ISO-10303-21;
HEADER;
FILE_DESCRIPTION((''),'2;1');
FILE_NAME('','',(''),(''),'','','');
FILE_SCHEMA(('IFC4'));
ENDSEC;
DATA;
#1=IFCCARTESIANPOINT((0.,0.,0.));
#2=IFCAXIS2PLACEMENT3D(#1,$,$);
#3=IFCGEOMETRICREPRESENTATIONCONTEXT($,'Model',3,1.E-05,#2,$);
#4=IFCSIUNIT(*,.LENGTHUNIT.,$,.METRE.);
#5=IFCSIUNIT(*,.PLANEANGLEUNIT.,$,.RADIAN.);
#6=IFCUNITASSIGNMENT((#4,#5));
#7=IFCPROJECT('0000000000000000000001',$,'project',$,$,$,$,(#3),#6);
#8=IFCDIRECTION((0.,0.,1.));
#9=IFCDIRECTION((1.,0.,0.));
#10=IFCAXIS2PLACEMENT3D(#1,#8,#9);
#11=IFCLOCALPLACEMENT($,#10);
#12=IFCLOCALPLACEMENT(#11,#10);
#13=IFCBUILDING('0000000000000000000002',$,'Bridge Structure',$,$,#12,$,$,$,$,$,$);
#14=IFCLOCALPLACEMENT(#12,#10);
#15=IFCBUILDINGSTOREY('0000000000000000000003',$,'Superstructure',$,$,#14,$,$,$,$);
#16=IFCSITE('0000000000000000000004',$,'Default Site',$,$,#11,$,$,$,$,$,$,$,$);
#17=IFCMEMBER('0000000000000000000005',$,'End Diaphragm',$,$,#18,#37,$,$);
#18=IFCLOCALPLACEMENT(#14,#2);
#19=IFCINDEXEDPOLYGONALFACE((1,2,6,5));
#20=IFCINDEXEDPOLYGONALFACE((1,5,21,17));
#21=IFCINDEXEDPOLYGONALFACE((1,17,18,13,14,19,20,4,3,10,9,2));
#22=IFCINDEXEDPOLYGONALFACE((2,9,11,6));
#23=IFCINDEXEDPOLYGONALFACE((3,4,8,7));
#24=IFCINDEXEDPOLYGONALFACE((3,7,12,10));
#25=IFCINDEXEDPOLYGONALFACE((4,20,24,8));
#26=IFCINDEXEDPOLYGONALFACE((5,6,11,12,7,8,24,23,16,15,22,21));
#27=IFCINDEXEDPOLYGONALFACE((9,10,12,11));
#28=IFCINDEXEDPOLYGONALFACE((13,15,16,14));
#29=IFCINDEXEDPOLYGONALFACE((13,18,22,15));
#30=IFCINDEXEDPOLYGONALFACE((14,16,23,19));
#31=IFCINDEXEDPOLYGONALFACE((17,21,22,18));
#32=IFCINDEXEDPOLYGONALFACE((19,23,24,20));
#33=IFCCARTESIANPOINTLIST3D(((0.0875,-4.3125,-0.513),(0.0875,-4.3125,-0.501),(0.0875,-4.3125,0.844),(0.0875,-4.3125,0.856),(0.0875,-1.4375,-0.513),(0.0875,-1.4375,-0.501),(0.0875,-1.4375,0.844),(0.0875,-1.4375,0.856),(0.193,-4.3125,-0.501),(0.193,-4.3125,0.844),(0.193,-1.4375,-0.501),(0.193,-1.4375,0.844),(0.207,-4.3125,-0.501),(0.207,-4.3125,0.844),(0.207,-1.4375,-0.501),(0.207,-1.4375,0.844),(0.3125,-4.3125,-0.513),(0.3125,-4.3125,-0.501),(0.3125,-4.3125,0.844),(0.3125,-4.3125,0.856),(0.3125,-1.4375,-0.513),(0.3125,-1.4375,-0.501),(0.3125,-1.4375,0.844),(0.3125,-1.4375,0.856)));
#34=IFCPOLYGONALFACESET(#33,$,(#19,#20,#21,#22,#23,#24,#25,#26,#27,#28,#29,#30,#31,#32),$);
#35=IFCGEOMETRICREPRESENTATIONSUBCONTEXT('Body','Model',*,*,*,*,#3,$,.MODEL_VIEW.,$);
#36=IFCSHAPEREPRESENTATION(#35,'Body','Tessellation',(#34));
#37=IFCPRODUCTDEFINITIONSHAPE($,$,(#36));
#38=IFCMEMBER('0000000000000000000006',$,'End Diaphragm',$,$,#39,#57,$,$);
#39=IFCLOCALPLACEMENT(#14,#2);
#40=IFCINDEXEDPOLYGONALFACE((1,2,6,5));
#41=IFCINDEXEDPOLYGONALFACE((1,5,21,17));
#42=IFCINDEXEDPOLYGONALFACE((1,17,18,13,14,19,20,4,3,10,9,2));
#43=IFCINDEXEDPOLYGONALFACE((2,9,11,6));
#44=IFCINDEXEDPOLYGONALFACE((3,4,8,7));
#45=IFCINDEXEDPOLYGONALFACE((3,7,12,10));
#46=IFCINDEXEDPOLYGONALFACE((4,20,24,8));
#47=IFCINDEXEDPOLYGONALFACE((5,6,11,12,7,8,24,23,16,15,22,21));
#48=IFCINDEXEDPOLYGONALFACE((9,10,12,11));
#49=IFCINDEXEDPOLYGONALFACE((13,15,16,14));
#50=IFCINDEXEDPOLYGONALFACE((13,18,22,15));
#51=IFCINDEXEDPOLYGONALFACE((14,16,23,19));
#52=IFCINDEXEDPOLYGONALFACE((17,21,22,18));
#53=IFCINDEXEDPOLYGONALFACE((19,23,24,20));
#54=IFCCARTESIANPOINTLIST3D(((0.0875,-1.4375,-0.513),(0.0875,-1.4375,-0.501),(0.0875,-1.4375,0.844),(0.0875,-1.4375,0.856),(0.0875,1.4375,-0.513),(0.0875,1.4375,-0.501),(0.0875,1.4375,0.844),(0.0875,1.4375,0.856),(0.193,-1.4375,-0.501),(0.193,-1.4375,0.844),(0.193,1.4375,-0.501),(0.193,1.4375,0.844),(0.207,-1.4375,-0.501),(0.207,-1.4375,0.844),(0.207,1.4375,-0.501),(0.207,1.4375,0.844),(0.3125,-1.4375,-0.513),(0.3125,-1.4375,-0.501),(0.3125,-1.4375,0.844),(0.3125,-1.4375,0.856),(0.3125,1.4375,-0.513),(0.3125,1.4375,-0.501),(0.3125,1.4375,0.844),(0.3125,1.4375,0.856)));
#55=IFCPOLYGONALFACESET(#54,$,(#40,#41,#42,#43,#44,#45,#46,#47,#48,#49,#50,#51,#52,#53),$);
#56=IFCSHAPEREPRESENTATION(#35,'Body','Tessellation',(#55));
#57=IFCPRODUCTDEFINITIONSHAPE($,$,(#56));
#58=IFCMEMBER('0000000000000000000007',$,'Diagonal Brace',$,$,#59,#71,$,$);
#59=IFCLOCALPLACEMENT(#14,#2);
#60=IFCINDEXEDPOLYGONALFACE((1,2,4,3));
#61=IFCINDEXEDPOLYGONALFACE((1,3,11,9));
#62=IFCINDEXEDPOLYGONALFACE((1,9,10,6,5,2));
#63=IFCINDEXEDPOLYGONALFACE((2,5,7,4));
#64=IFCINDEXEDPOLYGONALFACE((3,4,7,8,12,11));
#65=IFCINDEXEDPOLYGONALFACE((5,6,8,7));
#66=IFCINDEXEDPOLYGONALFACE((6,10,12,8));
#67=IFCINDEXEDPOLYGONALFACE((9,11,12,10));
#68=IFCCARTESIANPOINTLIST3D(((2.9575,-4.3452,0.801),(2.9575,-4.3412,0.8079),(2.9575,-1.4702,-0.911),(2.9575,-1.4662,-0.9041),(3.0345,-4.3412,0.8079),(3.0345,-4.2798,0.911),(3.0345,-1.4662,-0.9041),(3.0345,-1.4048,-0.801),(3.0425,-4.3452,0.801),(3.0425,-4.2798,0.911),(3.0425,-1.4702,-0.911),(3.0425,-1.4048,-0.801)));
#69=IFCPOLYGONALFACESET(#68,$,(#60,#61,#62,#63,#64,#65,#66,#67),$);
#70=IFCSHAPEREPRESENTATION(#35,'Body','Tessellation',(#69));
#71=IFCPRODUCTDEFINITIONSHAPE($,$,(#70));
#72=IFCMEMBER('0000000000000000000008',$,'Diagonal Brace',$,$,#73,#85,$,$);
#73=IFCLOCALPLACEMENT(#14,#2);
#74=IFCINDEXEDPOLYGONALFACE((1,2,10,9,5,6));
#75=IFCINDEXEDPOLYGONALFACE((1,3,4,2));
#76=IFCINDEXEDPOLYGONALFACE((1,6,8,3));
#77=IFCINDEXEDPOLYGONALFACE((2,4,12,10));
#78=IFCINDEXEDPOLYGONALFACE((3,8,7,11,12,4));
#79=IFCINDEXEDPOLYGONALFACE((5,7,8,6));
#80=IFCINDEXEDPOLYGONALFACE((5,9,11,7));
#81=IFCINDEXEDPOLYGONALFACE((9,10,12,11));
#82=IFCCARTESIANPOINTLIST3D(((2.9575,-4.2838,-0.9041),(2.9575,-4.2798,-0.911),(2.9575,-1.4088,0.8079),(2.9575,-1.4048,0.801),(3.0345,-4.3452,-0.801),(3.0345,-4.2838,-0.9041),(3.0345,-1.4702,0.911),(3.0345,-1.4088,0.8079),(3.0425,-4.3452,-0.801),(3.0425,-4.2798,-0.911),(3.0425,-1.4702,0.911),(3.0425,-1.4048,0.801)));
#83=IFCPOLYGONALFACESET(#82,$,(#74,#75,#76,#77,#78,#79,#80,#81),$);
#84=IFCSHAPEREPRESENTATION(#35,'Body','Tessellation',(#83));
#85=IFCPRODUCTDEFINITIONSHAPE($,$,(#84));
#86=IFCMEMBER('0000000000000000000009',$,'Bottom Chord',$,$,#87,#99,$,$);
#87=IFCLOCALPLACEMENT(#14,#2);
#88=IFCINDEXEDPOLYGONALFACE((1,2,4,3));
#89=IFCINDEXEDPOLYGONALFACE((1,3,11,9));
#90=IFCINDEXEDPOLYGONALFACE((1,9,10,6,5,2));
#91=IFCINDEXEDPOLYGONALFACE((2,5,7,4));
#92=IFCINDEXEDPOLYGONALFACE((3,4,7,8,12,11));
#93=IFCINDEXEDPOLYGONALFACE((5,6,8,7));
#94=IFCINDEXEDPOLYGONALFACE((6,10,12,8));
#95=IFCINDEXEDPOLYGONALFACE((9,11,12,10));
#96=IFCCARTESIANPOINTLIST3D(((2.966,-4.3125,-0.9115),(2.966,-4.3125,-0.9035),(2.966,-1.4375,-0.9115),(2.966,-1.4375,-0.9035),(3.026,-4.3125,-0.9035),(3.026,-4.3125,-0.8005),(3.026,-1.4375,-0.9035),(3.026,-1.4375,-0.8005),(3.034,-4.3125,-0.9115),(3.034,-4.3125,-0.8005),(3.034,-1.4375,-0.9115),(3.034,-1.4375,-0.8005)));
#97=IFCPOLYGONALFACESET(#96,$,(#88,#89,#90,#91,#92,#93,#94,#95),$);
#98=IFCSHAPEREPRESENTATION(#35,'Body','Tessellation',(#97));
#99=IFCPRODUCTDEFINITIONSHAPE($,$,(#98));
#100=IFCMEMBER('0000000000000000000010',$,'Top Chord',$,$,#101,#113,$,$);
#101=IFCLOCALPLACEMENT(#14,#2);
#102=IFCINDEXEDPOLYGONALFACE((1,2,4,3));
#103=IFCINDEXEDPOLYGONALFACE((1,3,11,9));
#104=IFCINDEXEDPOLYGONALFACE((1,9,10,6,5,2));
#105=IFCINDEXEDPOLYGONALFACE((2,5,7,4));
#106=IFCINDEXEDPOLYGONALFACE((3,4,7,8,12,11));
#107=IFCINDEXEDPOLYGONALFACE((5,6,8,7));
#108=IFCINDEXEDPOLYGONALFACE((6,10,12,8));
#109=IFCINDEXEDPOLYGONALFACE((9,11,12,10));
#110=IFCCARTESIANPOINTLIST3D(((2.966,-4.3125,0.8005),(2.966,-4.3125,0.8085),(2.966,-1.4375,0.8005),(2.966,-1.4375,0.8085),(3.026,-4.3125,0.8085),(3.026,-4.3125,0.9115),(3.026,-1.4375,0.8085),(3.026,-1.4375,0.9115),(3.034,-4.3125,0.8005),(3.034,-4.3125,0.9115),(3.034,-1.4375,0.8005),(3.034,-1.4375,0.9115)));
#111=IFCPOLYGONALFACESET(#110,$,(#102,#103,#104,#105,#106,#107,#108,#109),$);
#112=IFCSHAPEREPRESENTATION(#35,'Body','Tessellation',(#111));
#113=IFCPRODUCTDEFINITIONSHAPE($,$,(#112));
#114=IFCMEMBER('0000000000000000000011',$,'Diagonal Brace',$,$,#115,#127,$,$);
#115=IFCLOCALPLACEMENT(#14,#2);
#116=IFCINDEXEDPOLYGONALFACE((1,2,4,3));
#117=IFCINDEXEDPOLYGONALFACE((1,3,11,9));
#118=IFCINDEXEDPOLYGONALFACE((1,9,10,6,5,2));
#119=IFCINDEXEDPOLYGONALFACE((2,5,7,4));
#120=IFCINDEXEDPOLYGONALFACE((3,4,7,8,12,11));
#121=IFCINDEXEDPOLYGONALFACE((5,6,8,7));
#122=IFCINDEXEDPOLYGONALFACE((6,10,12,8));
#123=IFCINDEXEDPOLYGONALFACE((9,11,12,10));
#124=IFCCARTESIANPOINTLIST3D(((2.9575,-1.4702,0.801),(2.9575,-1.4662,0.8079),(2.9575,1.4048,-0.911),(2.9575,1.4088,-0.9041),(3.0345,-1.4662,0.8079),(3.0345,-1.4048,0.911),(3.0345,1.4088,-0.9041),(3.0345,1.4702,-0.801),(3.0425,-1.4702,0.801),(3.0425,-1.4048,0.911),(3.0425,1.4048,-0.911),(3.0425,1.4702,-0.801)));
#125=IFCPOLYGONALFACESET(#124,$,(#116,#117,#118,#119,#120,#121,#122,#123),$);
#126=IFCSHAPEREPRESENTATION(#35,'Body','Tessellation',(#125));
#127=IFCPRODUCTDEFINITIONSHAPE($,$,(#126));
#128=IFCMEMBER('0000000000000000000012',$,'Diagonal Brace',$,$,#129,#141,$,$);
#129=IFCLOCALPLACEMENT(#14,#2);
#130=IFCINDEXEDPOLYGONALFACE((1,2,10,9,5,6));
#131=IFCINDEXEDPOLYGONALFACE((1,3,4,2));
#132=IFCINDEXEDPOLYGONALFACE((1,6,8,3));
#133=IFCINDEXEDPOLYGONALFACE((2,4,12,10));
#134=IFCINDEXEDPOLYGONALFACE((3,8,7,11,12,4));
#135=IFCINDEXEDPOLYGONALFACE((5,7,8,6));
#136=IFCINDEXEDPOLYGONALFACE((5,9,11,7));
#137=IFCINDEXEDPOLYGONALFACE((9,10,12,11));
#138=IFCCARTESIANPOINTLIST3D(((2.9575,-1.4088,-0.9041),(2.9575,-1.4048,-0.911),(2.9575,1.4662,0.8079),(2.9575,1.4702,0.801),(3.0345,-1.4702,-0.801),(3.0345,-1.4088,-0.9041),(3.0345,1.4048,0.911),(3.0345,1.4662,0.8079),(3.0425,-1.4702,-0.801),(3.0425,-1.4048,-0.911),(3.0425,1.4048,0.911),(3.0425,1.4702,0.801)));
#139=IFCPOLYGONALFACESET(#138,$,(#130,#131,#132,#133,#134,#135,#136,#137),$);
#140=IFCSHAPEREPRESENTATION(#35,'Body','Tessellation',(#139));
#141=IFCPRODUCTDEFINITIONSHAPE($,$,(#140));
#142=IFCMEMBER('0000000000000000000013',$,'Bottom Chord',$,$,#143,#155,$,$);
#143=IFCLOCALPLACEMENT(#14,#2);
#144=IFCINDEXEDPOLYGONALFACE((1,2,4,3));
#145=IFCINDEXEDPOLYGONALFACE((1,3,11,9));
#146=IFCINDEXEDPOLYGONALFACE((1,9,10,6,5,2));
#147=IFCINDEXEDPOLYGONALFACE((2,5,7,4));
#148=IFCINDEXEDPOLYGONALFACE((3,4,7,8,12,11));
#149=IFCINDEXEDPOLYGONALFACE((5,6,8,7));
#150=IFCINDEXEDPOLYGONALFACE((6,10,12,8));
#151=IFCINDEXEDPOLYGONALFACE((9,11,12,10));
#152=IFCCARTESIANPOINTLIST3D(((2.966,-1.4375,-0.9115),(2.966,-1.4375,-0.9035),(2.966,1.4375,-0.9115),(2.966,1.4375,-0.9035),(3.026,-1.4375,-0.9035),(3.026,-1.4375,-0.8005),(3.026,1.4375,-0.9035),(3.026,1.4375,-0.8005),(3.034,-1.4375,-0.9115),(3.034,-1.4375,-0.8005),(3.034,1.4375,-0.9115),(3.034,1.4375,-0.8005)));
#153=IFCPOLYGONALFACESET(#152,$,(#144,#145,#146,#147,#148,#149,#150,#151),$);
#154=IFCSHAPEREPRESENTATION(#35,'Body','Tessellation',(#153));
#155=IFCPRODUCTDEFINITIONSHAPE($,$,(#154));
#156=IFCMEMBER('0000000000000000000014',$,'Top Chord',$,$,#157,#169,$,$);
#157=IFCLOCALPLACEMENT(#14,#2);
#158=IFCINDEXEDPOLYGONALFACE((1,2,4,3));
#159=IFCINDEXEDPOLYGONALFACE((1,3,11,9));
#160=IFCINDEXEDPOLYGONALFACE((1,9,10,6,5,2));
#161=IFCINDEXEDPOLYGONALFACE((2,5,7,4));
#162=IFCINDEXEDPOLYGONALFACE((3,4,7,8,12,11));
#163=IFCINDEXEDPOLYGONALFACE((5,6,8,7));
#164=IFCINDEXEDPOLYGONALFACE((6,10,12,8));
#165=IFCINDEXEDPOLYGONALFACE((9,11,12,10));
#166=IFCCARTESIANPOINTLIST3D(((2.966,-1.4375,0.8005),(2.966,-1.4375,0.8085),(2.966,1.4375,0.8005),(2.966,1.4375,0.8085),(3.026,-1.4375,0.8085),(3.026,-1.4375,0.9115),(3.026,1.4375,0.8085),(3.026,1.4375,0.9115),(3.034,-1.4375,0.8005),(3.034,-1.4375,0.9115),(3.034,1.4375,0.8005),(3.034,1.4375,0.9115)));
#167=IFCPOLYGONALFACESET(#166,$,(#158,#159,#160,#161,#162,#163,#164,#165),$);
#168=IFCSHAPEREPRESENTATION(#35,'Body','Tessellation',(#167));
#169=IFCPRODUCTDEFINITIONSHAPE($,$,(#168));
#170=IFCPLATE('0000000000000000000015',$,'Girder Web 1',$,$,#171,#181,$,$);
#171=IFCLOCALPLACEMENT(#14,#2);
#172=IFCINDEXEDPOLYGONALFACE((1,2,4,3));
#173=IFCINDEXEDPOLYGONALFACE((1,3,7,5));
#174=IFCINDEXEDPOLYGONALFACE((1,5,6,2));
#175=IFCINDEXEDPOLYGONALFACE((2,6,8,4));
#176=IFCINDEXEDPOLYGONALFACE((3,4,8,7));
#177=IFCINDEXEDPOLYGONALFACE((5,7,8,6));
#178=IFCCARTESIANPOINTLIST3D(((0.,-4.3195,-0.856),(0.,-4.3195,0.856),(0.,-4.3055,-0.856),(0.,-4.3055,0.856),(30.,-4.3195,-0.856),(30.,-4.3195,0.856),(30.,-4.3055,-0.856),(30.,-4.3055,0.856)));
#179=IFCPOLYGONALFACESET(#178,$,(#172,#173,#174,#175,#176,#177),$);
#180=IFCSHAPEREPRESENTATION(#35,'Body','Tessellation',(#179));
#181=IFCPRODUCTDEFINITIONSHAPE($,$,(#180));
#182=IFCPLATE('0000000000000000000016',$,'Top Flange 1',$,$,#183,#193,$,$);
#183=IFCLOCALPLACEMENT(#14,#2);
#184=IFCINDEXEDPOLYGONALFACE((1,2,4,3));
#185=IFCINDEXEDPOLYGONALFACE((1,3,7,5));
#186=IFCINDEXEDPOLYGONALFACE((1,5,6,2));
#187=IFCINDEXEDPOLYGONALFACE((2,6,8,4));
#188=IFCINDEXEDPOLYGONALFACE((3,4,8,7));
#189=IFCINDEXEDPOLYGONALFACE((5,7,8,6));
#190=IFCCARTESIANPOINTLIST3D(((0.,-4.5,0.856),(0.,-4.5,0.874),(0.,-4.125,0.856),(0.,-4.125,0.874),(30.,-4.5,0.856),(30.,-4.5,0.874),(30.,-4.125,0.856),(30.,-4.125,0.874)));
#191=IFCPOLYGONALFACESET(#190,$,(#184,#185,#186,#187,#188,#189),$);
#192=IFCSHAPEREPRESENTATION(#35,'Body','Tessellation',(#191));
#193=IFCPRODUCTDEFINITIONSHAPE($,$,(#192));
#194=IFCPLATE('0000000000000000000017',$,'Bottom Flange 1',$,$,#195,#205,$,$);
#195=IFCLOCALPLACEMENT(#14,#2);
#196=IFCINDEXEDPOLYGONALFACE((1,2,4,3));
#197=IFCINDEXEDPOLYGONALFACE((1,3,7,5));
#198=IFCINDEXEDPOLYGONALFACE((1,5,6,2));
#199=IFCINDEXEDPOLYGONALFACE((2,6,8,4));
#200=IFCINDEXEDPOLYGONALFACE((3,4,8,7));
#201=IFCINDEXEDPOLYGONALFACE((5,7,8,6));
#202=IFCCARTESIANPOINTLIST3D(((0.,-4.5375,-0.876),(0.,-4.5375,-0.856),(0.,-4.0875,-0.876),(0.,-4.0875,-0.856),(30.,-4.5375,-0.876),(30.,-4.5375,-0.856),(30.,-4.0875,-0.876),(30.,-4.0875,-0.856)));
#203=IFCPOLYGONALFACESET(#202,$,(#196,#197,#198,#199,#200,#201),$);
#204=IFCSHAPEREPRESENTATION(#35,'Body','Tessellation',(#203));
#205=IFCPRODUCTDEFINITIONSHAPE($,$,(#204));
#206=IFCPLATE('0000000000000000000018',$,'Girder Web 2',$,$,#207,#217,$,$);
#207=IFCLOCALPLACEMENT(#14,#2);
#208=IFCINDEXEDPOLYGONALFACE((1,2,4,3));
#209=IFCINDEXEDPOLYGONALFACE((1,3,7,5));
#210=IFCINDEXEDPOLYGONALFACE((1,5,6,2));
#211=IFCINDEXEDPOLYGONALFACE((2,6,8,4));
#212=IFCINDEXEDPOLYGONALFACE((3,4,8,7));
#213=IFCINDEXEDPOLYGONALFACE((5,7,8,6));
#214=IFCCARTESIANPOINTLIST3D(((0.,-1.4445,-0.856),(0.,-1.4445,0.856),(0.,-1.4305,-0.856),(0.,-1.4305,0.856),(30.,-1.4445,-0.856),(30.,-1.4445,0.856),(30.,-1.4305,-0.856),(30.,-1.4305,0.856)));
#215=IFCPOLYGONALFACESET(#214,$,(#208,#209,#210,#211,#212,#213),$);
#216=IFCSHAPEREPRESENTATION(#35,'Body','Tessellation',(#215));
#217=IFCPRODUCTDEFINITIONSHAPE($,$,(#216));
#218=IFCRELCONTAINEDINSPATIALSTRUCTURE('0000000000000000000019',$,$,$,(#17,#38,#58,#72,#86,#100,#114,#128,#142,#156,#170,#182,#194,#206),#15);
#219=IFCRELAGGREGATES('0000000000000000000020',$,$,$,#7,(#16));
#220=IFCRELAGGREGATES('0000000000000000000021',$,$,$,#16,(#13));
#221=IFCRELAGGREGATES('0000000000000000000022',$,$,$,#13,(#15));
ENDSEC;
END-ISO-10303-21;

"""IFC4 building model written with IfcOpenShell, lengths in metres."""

from ifc_helpers import new_model, si_unit, frame, origin, origin_with_axes, origin_2d_with_axis, place, context, subcontext, project, spatial, rectangle, i_section, l_section, extrude, element, save


model = new_model("IFC4")

# Units and contexts
model_context = context("Model", 3, precision=1e-05, world=origin())
body_context = subcontext(model_context, "Body", "Model", "MODEL_VIEW")
ifc_project = project(units=[si_unit("LENGTHUNIT", "METRE"), si_unit("PLANEANGLEUNIT", "RADIAN")], contexts=[model_context])

# Site, building, storey
site_placement = place(None, origin_with_axes())
site = spatial("IfcSite", under=ifc_project, at=site_placement, Name="Default Site")
building_placement = place(site_placement, origin_with_axes())
building = spatial("IfcBuilding", under=site, at=building_placement, Name="Bridge Structure")
storey_placement = place(building_placement, origin_with_axes())
storey = spatial("IfcBuildingStorey", under=building, at=storey_placement, Name="Superstructure")

# Members
for number, where, z_axis, x_axis, name in (
    (1, (0.2, -4.3125, 0.1715), (0.0, 1.0, 0.0), (-1.0, 0.0, 0.0), "End Diaphragm"),
    (2, (0.2, -1.4375, 0.1715), (0.0, 1.0, 0.0), (-1.0, 0.0, 0.0), "End Diaphragm"),
):
    element("IfcMember", number, at=place(storey_placement, frame(where, z_axis=z_axis, x_axis=x_axis)), inside=storey, Name=name, context=body_context, shape_type="SweptSolid", body=[
        extrude(i_section(OverallWidth=0.225, OverallDepth=1.369, WebThickness=0.014, FlangeThickness=0.012, at=origin_2d_with_axis()), origin_with_axes(), (0.0, 0.0, 1.0), 2.875),
    ])
for number, where, z_axis, x_axis, name in (
    (3, (3.0, -4.3125, 0.856), (0.0, 0.859202, -0.511636), (-1.0, 0.0, 0.0), "Diagonal Brace"),
    (4, (3.0, -4.3125, -0.856), (0.0, 0.859202, 0.511636), (-1.0, 0.0, 0.0), "Diagonal Brace"),
):
    element("IfcMember", number, at=place(storey_placement, frame(where, z_axis=z_axis, x_axis=x_axis)), inside=storey, Name=name, context=body_context, shape_type="SweptSolid", body=[
        extrude(l_section(Depth=0.128, Width=0.085, Thickness=0.008, at=origin_2d_with_axis()), origin_with_axes(), (0.0, 0.0, 1.0), 3.3461),
    ])
for number, where, z_axis, x_axis, name in (
    (5, (3.0, -4.3125, -0.856), (0.0, 1.0, 0.0), (-1.0, 0.0, 0.0), "Bottom Chord"),
    (6, (3.0, -4.3125, 0.856), (0.0, 1.0, 0.0), (-1.0, 0.0, 0.0), "Top Chord"),
):
    element("IfcMember", number, at=place(storey_placement, frame(where, z_axis=z_axis, x_axis=x_axis)), inside=storey, Name=name, context=body_context, shape_type="SweptSolid", body=[
        extrude(l_section(Depth=0.111, Width=0.068, Thickness=0.008, at=origin_2d_with_axis()), origin_with_axes(), (0.0, 0.0, 1.0), 2.875),
    ])
for number, where, z_axis, x_axis, name in (
    (7, (3.0, -1.4375, 0.856), (0.0, 0.859202, -0.511636), (-1.0, 0.0, 0.0), "Diagonal Brace"),
    (8, (3.0, -1.4375, -0.856), (0.0, 0.859202, 0.511636), (-1.0, 0.0, 0.0), "Diagonal Brace"),
):
    element("IfcMember", number, at=place(storey_placement, frame(where, z_axis=z_axis, x_axis=x_axis)), inside=storey, Name=name, context=body_context, shape_type="SweptSolid", body=[
        extrude(l_section(Depth=0.128, Width=0.085, Thickness=0.008, at=origin_2d_with_axis()), origin_with_axes(), (0.0, 0.0, 1.0), 3.3461),
    ])
for number, where, z_axis, x_axis, name in (
    (9, (3.0, -1.4375, -0.856), (0.0, 1.0, 0.0), (-1.0, 0.0, 0.0), "Bottom Chord"),
    (10, (3.0, -1.4375, 0.856), (0.0, 1.0, 0.0), (-1.0, 0.0, 0.0), "Top Chord"),
):
    element("IfcMember", number, at=place(storey_placement, frame(where, z_axis=z_axis, x_axis=x_axis)), inside=storey, Name=name, context=body_context, shape_type="SweptSolid", body=[
        extrude(l_section(Depth=0.111, Width=0.068, Thickness=0.008, at=origin_2d_with_axis()), origin_with_axes(), (0.0, 0.0, 1.0), 2.875),
    ])

# Plates
plate_1_placement = place(storey_placement, frame((0.0, -4.3125, 0.0), z_axis=(1.0, 0.0, 0.0), x_axis=(0.0, 1.0, 0.0)))
element("IfcPlate", 11, at=plate_1_placement, inside=storey, Name="Girder Web 1", context=body_context, shape_type="SweptSolid", body=[
    extrude(rectangle(XDim=0.014, YDim=1.712, at=origin_2d_with_axis()), origin_with_axes(), (0.0, 0.0, 1.0), 30.0),
])
plate_2_placement = place(storey_placement, frame((0.0, -4.3125, 0.865), z_axis=(1.0, 0.0, 0.0), x_axis=(0.0, 1.0, 0.0)))
element("IfcPlate", 12, at=plate_2_placement, inside=storey, Name="Top Flange 1", context=body_context, shape_type="SweptSolid", body=[
    extrude(rectangle(XDim=0.375, YDim=0.018, at=origin_2d_with_axis()), origin_with_axes(), (0.0, 0.0, 1.0), 30.0),
])
plate_3_placement = place(storey_placement, frame((0.0, -4.3125, -0.866), z_axis=(1.0, 0.0, 0.0), x_axis=(0.0, 1.0, 0.0)))
element("IfcPlate", 13, at=plate_3_placement, inside=storey, Name="Bottom Flange 1", context=body_context, shape_type="SweptSolid", body=[
    extrude(rectangle(XDim=0.45, YDim=0.02, at=origin_2d_with_axis()), origin_with_axes(), (0.0, 0.0, 1.0), 30.0),
])
plate_4_placement = place(storey_placement, frame((0.0, -1.4375, 0.0), z_axis=(1.0, 0.0, 0.0), x_axis=(0.0, 1.0, 0.0)))
element("IfcPlate", 14, at=plate_4_placement, inside=storey, Name="Girder Web 2", context=body_context, shape_type="SweptSolid", body=[
    extrude(rectangle(XDim=0.014, YDim=1.712, at=origin_2d_with_axis()), origin_with_axes(), (0.0, 0.0, 1.0), 30.0),
])

save(model, "model.ifc")
